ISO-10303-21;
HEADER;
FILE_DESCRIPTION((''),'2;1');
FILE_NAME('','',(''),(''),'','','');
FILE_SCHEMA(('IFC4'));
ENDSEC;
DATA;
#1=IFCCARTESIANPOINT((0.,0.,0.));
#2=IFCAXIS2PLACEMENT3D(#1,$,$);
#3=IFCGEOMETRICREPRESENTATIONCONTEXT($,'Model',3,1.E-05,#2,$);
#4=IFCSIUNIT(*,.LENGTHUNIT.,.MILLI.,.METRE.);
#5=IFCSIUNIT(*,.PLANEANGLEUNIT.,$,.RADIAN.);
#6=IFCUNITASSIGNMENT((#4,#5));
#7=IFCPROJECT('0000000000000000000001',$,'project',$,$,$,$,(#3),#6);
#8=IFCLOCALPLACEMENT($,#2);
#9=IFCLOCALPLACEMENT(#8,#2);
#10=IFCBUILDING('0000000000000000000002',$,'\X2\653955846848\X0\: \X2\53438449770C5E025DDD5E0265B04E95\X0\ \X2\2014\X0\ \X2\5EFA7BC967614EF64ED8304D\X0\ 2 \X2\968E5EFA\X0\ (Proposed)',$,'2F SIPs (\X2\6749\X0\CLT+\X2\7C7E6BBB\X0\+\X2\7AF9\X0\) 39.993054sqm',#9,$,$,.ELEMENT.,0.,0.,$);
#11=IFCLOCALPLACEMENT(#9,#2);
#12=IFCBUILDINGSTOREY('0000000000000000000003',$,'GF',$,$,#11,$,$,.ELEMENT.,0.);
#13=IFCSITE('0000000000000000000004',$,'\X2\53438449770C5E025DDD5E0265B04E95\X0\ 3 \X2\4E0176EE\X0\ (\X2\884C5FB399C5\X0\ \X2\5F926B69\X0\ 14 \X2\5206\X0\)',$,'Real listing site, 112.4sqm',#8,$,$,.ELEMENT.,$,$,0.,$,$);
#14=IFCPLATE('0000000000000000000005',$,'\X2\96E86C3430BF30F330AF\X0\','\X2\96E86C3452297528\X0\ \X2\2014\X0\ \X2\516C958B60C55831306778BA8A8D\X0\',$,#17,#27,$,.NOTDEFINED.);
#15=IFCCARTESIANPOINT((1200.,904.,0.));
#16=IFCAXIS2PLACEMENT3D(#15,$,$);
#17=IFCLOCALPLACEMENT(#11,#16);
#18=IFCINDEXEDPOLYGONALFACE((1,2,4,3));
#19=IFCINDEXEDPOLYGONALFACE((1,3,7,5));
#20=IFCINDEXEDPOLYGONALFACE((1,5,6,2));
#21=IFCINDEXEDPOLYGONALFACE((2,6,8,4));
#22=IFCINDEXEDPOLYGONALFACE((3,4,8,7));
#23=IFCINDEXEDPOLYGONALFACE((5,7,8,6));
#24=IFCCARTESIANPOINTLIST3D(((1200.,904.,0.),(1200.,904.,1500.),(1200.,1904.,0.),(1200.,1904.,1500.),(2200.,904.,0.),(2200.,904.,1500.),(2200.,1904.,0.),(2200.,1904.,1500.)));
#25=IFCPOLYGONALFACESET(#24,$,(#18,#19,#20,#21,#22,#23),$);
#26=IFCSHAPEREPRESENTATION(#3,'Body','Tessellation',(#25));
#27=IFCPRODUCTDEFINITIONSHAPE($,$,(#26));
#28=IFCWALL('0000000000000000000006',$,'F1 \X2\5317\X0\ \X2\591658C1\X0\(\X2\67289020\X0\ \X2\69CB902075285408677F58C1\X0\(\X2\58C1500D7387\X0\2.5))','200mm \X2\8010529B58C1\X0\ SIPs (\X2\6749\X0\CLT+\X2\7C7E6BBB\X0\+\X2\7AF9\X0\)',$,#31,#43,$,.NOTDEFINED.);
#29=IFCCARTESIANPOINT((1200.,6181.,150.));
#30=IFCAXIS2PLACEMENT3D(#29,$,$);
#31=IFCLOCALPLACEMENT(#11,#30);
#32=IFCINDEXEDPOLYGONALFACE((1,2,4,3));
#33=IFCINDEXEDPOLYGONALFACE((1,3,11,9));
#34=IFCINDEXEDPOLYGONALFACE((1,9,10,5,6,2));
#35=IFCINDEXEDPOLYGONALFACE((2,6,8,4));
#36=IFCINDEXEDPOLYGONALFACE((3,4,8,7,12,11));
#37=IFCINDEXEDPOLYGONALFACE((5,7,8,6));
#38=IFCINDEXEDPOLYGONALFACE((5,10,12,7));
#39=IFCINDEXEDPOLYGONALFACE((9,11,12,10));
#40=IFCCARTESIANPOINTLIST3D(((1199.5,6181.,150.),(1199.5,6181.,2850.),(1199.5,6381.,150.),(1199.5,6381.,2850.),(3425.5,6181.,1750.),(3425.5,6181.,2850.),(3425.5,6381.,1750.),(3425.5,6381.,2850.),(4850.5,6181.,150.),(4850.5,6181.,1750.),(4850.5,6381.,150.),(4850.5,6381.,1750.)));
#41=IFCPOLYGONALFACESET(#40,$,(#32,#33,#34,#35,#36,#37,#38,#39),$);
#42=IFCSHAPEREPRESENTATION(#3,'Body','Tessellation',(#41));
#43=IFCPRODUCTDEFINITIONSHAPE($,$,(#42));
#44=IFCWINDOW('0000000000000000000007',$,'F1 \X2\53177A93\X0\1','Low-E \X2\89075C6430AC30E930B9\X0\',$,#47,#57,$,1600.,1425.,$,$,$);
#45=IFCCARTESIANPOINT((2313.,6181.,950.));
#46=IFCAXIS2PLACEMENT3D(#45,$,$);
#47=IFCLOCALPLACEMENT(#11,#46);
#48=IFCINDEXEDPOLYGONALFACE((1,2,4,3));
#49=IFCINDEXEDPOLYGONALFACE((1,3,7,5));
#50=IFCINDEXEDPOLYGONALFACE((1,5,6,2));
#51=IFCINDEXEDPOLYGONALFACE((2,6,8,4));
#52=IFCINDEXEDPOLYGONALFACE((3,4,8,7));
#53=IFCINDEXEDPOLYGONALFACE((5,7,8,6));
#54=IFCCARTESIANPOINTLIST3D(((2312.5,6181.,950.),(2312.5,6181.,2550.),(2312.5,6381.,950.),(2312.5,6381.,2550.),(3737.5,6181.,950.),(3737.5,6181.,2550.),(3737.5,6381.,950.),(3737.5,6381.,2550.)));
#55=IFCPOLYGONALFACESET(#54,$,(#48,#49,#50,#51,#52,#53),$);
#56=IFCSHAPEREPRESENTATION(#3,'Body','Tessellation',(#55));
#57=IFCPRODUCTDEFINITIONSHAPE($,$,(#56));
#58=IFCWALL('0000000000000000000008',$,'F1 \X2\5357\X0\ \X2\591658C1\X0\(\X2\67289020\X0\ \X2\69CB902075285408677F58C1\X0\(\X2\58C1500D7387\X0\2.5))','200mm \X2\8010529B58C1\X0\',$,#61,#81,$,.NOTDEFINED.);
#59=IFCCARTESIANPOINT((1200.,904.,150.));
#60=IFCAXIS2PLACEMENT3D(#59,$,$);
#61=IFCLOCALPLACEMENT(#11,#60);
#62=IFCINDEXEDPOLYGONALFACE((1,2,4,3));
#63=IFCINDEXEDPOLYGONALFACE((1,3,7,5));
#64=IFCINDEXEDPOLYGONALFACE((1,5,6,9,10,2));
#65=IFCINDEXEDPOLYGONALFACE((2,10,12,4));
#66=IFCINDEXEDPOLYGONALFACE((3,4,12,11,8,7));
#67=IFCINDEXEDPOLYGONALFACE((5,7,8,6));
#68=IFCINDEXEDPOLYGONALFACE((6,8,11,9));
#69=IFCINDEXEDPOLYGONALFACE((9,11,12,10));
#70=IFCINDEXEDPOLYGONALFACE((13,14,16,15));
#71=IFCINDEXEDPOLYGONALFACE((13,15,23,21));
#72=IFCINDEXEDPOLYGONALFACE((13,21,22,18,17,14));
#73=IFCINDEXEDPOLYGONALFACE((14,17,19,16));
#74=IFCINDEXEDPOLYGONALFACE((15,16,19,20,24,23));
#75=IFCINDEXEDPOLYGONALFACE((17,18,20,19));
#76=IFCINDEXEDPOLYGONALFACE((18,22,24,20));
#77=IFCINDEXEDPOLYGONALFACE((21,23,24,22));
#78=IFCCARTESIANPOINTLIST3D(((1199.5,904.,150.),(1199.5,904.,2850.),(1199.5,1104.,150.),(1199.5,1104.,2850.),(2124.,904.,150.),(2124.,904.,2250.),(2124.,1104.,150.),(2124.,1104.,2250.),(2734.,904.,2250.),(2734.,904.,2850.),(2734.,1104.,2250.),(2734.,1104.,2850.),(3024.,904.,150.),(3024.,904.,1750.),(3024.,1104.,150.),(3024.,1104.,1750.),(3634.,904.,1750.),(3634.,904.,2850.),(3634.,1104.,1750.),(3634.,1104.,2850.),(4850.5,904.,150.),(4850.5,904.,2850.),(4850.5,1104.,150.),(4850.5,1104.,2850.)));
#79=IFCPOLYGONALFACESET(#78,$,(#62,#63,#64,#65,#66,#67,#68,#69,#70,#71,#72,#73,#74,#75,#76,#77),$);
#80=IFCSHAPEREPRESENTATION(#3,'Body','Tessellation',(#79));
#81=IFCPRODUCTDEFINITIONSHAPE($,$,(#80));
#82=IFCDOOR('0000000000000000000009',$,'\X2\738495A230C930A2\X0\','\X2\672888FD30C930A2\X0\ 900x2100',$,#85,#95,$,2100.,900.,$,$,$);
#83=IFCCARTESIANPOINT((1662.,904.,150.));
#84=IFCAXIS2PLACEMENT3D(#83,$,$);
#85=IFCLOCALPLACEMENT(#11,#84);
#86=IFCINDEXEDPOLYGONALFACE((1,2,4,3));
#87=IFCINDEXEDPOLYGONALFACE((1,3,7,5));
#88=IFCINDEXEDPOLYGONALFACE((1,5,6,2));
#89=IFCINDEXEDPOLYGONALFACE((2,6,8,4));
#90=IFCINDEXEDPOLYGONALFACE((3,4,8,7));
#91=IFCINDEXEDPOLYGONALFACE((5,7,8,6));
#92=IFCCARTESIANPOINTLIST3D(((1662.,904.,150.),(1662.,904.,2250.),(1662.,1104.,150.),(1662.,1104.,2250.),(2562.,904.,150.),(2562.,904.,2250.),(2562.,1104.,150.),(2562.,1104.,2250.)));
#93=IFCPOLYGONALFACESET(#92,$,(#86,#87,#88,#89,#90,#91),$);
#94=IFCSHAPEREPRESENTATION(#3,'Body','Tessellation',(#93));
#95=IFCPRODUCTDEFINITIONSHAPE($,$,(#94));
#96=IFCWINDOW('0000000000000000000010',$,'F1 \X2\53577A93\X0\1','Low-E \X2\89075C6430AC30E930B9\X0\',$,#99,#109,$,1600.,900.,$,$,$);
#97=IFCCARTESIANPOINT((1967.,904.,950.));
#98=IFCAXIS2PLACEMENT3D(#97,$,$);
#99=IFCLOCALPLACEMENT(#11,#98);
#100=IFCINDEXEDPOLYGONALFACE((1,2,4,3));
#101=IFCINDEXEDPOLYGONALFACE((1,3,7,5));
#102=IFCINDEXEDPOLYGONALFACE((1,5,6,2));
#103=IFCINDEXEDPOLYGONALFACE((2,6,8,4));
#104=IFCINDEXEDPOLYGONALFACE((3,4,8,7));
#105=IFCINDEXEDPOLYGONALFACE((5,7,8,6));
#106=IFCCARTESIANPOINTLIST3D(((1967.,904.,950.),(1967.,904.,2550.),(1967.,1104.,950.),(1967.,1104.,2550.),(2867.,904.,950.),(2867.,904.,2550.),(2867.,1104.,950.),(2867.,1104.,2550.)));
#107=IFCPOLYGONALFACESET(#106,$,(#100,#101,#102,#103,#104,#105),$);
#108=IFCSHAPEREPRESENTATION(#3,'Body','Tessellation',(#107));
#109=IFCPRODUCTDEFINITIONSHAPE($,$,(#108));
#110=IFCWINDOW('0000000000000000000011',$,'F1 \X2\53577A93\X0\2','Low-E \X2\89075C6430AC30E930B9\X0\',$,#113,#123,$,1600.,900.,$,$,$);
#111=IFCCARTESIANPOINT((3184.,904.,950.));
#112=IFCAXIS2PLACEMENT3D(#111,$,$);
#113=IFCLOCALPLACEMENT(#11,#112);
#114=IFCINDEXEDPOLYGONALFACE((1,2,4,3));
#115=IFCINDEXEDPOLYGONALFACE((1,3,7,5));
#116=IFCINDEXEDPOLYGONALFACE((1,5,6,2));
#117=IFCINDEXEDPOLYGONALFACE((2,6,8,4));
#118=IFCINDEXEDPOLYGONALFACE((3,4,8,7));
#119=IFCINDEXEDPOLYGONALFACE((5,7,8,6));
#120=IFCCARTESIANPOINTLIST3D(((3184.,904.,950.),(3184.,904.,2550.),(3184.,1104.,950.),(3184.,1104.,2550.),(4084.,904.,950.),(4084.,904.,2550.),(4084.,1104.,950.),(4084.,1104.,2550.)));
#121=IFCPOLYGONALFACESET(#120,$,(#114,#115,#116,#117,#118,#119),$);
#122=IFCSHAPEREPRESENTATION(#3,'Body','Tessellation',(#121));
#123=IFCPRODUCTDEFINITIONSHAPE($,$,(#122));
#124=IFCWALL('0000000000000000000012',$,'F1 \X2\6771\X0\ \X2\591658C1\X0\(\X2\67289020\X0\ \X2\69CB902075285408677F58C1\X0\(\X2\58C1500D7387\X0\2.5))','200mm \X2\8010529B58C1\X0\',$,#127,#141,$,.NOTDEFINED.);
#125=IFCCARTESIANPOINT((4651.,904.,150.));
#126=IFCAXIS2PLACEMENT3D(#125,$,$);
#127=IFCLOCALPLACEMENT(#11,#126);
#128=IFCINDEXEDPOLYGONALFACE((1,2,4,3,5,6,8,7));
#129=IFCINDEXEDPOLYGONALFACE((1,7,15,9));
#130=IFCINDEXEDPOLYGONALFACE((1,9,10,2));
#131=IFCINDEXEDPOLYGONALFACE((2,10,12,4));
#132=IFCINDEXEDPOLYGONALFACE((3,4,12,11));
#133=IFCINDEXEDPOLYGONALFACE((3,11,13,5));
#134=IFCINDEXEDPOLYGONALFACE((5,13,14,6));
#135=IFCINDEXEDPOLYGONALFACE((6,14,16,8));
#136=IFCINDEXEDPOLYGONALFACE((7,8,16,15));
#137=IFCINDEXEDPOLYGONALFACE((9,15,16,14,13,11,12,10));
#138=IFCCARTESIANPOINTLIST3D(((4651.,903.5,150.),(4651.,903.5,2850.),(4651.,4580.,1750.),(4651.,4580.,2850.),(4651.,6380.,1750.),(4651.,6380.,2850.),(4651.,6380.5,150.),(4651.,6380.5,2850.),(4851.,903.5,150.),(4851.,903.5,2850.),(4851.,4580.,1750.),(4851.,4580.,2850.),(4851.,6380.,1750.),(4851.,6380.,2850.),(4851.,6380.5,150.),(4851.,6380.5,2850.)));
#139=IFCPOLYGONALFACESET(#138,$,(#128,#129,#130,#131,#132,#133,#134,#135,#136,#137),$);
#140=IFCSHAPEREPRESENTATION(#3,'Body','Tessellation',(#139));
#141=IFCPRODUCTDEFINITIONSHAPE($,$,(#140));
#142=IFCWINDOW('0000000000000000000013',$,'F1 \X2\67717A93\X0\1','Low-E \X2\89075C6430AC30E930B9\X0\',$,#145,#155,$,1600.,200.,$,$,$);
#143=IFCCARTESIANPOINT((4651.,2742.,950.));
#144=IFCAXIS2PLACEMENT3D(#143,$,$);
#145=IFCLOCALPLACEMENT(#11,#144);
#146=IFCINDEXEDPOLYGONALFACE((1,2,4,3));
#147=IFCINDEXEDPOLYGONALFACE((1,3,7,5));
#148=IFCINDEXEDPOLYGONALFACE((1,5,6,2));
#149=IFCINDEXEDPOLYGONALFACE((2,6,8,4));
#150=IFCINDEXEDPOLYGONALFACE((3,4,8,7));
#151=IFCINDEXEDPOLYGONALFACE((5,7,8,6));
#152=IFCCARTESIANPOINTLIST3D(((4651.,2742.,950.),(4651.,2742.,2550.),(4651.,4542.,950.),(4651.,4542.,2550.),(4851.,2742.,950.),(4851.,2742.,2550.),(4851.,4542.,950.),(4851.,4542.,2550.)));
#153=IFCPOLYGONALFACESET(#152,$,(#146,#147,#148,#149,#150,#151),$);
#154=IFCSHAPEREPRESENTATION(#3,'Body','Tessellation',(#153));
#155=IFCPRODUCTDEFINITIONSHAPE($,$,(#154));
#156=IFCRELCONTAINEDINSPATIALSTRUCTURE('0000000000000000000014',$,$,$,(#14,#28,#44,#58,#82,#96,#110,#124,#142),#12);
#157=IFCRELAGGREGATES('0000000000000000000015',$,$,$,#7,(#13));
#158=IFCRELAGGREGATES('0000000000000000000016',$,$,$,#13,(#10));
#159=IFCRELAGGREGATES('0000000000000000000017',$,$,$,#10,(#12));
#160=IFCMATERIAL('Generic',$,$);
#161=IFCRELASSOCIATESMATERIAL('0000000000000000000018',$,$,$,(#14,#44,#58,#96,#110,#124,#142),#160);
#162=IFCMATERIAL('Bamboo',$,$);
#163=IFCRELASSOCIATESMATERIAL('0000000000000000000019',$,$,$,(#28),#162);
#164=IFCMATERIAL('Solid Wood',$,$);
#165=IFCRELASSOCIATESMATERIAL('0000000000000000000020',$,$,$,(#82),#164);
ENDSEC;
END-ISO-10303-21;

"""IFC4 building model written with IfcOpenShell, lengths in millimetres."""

from ifc_helpers import new_model, si_unit, frame, frame_2d, origin, place, context, project, spatial, rectangle, extrude, material, element, fill, save


model = new_model("IFC4")

# Units and contexts
model_context = context("Model", 3, precision=1e-05, world=origin())
ifc_project = project(units=[si_unit("LENGTHUNIT", "METRE", prefix="MILLI"), si_unit("PLANEANGLEUNIT", "RADIAN")], contexts=[model_context])

# Site, building, storey
site_placement = place(None, origin())
site = spatial("IfcSite", under=ifc_project, at=site_placement, Name="千葉県市川市新井 3 丁目 (行徳駅 徒歩 14 分)", ObjectType="Real listing site, 112.4sqm", CompositionType="ELEMENT", RefElevation=0.0)
building_placement = place(site_placement, origin())
building = spatial("IfcBuilding", under=site, at=building_placement, Name="改善案: 千葉県市川市新井 — 建築条件付き 2 階建 (Proposed)", ObjectType="2F SIPs (杉CLT+籾殻+竹) 39.993054sqm", CompositionType="ELEMENT", ElevationOfRefHeight=0.0, ElevationOfTerrain=0.0)
storey_placement = place(building_placement, origin())
storey = spatial("IfcBuildingStorey", under=building, at=storey_placement, Name="GF", CompositionType="ELEMENT", Elevation=0.0)

# Shared definitions
ifc_material_1 = material(Name="Generic")

# Plate
plate_placement = place(storey_placement, frame((1200.0, 904.0, 0.0)))
element("IfcPlate", 1, at=plate_placement, inside=storey, material=ifc_material_1, Name="雨水タンク", Description="雨水利用 — 公開情報で確認", PredefinedType="NOTDEFINED", context=model_context, shape_type="SweptSolid", body=[
    extrude(rectangle(XDim=1000.0, YDim=1000.0, at=frame_2d((500.0, 500.0))), frame((1200.0, 904.0, 0.0)), (0.0, 0.0, 1.0), 1500.0),
])

# Wall, opening, window
ifc_material_2 = material(Name="Bamboo")
wall_1_placement = place(storey_placement, frame((1200.0, 6181.0, 150.0)))
wall_1 = element("IfcWall", 2, at=wall_1_placement, inside=storey, material=ifc_material_2, Name="F1 北 外壁(木造 構造用合板壁(壁倍率2.5))", Description="200mm 耐力壁 SIPs (杉CLT+籾殻+竹)", PredefinedType="NOTDEFINED", context=model_context, shape_type="SweptSolid", body=[
    extrude(rectangle(XDim=3651.0, YDim=200.0, at=frame_2d((1825.0, 100.0))), frame((1200.0, 6181.0, 150.0)), (0.0, 0.0, 1.0), 2700.0),
])
opening_1_placement = place(storey_placement, frame((2313.0, 6181.0, 950.0)))
opening_1 = element("IfcOpeningElement", 3, at=opening_1_placement, cuts=wall_1, PredefinedType="NOTDEFINED", context=model_context, shape_type="SweptSolid", body=[
    extrude(rectangle(XDim=1425.0, YDim=200.0, at=frame_2d((712.0, 100.0))), frame((2313.0, 6181.0, 950.0)), (0.0, 0.0, 1.0), 1600.0),
])
window_1_placement = place(storey_placement, frame((2313.0, 6181.0, 950.0)))
window_1 = element("IfcWindow", 4, at=window_1_placement, inside=storey, material=ifc_material_1, Name="F1 北窓1", Description="Low-E 複層ガラス", OverallHeight=1600.0, OverallWidth=1425.0, context=model_context, shape_type="SweptSolid", body=[
    extrude(rectangle(XDim=1425.0, YDim=200.0, at=frame_2d((712.0, 100.0))), frame((2313.0, 6181.0, 950.0)), (0.0, 0.0, 1.0), 1600.0),
])
fill(opening_1, window_1)

# Wall, openings, door, windows
wall_2_placement = place(storey_placement, frame((1200.0, 904.0, 150.0)))
wall_2 = element("IfcWall", 5, at=wall_2_placement, inside=storey, material=ifc_material_1, Name="F1 南 外壁(木造 構造用合板壁(壁倍率2.5))", Description="200mm 耐力壁", PredefinedType="NOTDEFINED", context=model_context, shape_type="SweptSolid", body=[
    extrude(rectangle(XDim=3651.0, YDim=200.0, at=frame_2d((1825.0, 100.0))), frame((1200.0, 904.0, 150.0)), (0.0, 0.0, 1.0), 2700.0),
])
opening_2_placement = place(storey_placement, frame((1662.0, 904.0, 150.0)))
opening_2 = element("IfcOpeningElement", 6, at=opening_2_placement, cuts=wall_2, PredefinedType="NOTDEFINED", context=model_context, shape_type="SweptSolid", body=[
    extrude(rectangle(XDim=900.0, YDim=200.0, at=frame_2d((450.0, 100.0))), frame((1662.0, 904.0, 150.0)), (0.0, 0.0, 1.0), 2100.0),
])
opening_3_placement = place(storey_placement, frame((1967.0, 904.0, 950.0)))
opening_3 = element("IfcOpeningElement", 7, at=opening_3_placement, cuts=wall_2, PredefinedType="NOTDEFINED", context=model_context, shape_type="SweptSolid", body=[
    extrude(rectangle(XDim=900.0, YDim=200.0, at=frame_2d((450.0, 100.0))), frame((1967.0, 904.0, 950.0)), (0.0, 0.0, 1.0), 1600.0),
])
opening_4_placement = place(storey_placement, frame((3184.0, 904.0, 950.0)))
opening_4 = element("IfcOpeningElement", 8, at=opening_4_placement, cuts=wall_2, PredefinedType="NOTDEFINED", context=model_context, shape_type="SweptSolid", body=[
    extrude(rectangle(XDim=900.0, YDim=200.0, at=frame_2d((450.0, 100.0))), frame((3184.0, 904.0, 950.0)), (0.0, 0.0, 1.0), 1600.0),
])
ifc_material_3 = material(Name="Solid Wood")
door_placement = place(storey_placement, frame((1662.0, 904.0, 150.0)))
door = element("IfcDoor", 9, at=door_placement, inside=storey, material=ifc_material_3, Name="玄関ドア", Description="木製ドア 900x2100", OverallHeight=2100.0, OverallWidth=900.0, context=model_context, shape_type="SweptSolid", body=[
    extrude(rectangle(XDim=900.0, YDim=200.0, at=frame_2d((450.0, 100.0))), frame((1662.0, 904.0, 150.0)), (0.0, 0.0, 1.0), 2100.0),
])
fill(opening_2, door)
window_2_placement = place(storey_placement, frame((1967.0, 904.0, 950.0)))
window_2 = element("IfcWindow", 10, at=window_2_placement, inside=storey, material=ifc_material_1, Name="F1 南窓1", Description="Low-E 複層ガラス", OverallHeight=1600.0, OverallWidth=900.0, context=model_context, shape_type="SweptSolid", body=[
    extrude(rectangle(XDim=900.0, YDim=200.0, at=frame_2d((450.0, 100.0))), frame((1967.0, 904.0, 950.0)), (0.0, 0.0, 1.0), 1600.0),
])
fill(opening_3, window_2)
window_3_placement = place(storey_placement, frame((3184.0, 904.0, 950.0)))
window_3 = element("IfcWindow", 11, at=window_3_placement, inside=storey, material=ifc_material_1, Name="F1 南窓2", Description="Low-E 複層ガラス", OverallHeight=1600.0, OverallWidth=900.0, context=model_context, shape_type="SweptSolid", body=[
    extrude(rectangle(XDim=900.0, YDim=200.0, at=frame_2d((450.0, 100.0))), frame((3184.0, 904.0, 950.0)), (0.0, 0.0, 1.0), 1600.0),
])
fill(opening_4, window_3)

# Wall, opening, window
wall_3_placement = place(storey_placement, frame((4651.0, 904.0, 150.0)))
wall_3 = element("IfcWall", 12, at=wall_3_placement, inside=storey, material=ifc_material_1, Name="F1 東 外壁(木造 構造用合板壁(壁倍率2.5))", Description="200mm 耐力壁", PredefinedType="NOTDEFINED", context=model_context, shape_type="SweptSolid", body=[
    extrude(rectangle(XDim=200.0, YDim=5477.0, at=frame_2d((100.0, 2738.0))), frame((4651.0, 904.0, 150.0)), (0.0, 0.0, 1.0), 2700.0),
])
opening_5_placement = place(storey_placement, frame((4651.0, 2742.0, 950.0)))
opening_5 = element("IfcOpeningElement", 13, at=opening_5_placement, cuts=wall_3, PredefinedType="NOTDEFINED", context=model_context, shape_type="SweptSolid", body=[
    extrude(rectangle(XDim=200.0, YDim=1800.0, at=frame_2d((100.0, 900.0))), frame((4651.0, 2742.0, 950.0)), (0.0, 0.0, 1.0), 1600.0),
])
window_4_placement = place(storey_placement, frame((4651.0, 2742.0, 950.0)))
window_4 = element("IfcWindow", 14, at=window_4_placement, inside=storey, material=ifc_material_1, Name="F1 東窓1", Description="Low-E 複層ガラス", OverallHeight=1600.0, OverallWidth=200.0, context=model_context, shape_type="SweptSolid", body=[
    extrude(rectangle(XDim=200.0, YDim=1800.0, at=frame_2d((100.0, 900.0))), frame((4651.0, 2742.0, 950.0)), (0.0, 0.0, 1.0), 1600.0),
])
fill(opening_5, window_4)

save(model, "model.ifc")
